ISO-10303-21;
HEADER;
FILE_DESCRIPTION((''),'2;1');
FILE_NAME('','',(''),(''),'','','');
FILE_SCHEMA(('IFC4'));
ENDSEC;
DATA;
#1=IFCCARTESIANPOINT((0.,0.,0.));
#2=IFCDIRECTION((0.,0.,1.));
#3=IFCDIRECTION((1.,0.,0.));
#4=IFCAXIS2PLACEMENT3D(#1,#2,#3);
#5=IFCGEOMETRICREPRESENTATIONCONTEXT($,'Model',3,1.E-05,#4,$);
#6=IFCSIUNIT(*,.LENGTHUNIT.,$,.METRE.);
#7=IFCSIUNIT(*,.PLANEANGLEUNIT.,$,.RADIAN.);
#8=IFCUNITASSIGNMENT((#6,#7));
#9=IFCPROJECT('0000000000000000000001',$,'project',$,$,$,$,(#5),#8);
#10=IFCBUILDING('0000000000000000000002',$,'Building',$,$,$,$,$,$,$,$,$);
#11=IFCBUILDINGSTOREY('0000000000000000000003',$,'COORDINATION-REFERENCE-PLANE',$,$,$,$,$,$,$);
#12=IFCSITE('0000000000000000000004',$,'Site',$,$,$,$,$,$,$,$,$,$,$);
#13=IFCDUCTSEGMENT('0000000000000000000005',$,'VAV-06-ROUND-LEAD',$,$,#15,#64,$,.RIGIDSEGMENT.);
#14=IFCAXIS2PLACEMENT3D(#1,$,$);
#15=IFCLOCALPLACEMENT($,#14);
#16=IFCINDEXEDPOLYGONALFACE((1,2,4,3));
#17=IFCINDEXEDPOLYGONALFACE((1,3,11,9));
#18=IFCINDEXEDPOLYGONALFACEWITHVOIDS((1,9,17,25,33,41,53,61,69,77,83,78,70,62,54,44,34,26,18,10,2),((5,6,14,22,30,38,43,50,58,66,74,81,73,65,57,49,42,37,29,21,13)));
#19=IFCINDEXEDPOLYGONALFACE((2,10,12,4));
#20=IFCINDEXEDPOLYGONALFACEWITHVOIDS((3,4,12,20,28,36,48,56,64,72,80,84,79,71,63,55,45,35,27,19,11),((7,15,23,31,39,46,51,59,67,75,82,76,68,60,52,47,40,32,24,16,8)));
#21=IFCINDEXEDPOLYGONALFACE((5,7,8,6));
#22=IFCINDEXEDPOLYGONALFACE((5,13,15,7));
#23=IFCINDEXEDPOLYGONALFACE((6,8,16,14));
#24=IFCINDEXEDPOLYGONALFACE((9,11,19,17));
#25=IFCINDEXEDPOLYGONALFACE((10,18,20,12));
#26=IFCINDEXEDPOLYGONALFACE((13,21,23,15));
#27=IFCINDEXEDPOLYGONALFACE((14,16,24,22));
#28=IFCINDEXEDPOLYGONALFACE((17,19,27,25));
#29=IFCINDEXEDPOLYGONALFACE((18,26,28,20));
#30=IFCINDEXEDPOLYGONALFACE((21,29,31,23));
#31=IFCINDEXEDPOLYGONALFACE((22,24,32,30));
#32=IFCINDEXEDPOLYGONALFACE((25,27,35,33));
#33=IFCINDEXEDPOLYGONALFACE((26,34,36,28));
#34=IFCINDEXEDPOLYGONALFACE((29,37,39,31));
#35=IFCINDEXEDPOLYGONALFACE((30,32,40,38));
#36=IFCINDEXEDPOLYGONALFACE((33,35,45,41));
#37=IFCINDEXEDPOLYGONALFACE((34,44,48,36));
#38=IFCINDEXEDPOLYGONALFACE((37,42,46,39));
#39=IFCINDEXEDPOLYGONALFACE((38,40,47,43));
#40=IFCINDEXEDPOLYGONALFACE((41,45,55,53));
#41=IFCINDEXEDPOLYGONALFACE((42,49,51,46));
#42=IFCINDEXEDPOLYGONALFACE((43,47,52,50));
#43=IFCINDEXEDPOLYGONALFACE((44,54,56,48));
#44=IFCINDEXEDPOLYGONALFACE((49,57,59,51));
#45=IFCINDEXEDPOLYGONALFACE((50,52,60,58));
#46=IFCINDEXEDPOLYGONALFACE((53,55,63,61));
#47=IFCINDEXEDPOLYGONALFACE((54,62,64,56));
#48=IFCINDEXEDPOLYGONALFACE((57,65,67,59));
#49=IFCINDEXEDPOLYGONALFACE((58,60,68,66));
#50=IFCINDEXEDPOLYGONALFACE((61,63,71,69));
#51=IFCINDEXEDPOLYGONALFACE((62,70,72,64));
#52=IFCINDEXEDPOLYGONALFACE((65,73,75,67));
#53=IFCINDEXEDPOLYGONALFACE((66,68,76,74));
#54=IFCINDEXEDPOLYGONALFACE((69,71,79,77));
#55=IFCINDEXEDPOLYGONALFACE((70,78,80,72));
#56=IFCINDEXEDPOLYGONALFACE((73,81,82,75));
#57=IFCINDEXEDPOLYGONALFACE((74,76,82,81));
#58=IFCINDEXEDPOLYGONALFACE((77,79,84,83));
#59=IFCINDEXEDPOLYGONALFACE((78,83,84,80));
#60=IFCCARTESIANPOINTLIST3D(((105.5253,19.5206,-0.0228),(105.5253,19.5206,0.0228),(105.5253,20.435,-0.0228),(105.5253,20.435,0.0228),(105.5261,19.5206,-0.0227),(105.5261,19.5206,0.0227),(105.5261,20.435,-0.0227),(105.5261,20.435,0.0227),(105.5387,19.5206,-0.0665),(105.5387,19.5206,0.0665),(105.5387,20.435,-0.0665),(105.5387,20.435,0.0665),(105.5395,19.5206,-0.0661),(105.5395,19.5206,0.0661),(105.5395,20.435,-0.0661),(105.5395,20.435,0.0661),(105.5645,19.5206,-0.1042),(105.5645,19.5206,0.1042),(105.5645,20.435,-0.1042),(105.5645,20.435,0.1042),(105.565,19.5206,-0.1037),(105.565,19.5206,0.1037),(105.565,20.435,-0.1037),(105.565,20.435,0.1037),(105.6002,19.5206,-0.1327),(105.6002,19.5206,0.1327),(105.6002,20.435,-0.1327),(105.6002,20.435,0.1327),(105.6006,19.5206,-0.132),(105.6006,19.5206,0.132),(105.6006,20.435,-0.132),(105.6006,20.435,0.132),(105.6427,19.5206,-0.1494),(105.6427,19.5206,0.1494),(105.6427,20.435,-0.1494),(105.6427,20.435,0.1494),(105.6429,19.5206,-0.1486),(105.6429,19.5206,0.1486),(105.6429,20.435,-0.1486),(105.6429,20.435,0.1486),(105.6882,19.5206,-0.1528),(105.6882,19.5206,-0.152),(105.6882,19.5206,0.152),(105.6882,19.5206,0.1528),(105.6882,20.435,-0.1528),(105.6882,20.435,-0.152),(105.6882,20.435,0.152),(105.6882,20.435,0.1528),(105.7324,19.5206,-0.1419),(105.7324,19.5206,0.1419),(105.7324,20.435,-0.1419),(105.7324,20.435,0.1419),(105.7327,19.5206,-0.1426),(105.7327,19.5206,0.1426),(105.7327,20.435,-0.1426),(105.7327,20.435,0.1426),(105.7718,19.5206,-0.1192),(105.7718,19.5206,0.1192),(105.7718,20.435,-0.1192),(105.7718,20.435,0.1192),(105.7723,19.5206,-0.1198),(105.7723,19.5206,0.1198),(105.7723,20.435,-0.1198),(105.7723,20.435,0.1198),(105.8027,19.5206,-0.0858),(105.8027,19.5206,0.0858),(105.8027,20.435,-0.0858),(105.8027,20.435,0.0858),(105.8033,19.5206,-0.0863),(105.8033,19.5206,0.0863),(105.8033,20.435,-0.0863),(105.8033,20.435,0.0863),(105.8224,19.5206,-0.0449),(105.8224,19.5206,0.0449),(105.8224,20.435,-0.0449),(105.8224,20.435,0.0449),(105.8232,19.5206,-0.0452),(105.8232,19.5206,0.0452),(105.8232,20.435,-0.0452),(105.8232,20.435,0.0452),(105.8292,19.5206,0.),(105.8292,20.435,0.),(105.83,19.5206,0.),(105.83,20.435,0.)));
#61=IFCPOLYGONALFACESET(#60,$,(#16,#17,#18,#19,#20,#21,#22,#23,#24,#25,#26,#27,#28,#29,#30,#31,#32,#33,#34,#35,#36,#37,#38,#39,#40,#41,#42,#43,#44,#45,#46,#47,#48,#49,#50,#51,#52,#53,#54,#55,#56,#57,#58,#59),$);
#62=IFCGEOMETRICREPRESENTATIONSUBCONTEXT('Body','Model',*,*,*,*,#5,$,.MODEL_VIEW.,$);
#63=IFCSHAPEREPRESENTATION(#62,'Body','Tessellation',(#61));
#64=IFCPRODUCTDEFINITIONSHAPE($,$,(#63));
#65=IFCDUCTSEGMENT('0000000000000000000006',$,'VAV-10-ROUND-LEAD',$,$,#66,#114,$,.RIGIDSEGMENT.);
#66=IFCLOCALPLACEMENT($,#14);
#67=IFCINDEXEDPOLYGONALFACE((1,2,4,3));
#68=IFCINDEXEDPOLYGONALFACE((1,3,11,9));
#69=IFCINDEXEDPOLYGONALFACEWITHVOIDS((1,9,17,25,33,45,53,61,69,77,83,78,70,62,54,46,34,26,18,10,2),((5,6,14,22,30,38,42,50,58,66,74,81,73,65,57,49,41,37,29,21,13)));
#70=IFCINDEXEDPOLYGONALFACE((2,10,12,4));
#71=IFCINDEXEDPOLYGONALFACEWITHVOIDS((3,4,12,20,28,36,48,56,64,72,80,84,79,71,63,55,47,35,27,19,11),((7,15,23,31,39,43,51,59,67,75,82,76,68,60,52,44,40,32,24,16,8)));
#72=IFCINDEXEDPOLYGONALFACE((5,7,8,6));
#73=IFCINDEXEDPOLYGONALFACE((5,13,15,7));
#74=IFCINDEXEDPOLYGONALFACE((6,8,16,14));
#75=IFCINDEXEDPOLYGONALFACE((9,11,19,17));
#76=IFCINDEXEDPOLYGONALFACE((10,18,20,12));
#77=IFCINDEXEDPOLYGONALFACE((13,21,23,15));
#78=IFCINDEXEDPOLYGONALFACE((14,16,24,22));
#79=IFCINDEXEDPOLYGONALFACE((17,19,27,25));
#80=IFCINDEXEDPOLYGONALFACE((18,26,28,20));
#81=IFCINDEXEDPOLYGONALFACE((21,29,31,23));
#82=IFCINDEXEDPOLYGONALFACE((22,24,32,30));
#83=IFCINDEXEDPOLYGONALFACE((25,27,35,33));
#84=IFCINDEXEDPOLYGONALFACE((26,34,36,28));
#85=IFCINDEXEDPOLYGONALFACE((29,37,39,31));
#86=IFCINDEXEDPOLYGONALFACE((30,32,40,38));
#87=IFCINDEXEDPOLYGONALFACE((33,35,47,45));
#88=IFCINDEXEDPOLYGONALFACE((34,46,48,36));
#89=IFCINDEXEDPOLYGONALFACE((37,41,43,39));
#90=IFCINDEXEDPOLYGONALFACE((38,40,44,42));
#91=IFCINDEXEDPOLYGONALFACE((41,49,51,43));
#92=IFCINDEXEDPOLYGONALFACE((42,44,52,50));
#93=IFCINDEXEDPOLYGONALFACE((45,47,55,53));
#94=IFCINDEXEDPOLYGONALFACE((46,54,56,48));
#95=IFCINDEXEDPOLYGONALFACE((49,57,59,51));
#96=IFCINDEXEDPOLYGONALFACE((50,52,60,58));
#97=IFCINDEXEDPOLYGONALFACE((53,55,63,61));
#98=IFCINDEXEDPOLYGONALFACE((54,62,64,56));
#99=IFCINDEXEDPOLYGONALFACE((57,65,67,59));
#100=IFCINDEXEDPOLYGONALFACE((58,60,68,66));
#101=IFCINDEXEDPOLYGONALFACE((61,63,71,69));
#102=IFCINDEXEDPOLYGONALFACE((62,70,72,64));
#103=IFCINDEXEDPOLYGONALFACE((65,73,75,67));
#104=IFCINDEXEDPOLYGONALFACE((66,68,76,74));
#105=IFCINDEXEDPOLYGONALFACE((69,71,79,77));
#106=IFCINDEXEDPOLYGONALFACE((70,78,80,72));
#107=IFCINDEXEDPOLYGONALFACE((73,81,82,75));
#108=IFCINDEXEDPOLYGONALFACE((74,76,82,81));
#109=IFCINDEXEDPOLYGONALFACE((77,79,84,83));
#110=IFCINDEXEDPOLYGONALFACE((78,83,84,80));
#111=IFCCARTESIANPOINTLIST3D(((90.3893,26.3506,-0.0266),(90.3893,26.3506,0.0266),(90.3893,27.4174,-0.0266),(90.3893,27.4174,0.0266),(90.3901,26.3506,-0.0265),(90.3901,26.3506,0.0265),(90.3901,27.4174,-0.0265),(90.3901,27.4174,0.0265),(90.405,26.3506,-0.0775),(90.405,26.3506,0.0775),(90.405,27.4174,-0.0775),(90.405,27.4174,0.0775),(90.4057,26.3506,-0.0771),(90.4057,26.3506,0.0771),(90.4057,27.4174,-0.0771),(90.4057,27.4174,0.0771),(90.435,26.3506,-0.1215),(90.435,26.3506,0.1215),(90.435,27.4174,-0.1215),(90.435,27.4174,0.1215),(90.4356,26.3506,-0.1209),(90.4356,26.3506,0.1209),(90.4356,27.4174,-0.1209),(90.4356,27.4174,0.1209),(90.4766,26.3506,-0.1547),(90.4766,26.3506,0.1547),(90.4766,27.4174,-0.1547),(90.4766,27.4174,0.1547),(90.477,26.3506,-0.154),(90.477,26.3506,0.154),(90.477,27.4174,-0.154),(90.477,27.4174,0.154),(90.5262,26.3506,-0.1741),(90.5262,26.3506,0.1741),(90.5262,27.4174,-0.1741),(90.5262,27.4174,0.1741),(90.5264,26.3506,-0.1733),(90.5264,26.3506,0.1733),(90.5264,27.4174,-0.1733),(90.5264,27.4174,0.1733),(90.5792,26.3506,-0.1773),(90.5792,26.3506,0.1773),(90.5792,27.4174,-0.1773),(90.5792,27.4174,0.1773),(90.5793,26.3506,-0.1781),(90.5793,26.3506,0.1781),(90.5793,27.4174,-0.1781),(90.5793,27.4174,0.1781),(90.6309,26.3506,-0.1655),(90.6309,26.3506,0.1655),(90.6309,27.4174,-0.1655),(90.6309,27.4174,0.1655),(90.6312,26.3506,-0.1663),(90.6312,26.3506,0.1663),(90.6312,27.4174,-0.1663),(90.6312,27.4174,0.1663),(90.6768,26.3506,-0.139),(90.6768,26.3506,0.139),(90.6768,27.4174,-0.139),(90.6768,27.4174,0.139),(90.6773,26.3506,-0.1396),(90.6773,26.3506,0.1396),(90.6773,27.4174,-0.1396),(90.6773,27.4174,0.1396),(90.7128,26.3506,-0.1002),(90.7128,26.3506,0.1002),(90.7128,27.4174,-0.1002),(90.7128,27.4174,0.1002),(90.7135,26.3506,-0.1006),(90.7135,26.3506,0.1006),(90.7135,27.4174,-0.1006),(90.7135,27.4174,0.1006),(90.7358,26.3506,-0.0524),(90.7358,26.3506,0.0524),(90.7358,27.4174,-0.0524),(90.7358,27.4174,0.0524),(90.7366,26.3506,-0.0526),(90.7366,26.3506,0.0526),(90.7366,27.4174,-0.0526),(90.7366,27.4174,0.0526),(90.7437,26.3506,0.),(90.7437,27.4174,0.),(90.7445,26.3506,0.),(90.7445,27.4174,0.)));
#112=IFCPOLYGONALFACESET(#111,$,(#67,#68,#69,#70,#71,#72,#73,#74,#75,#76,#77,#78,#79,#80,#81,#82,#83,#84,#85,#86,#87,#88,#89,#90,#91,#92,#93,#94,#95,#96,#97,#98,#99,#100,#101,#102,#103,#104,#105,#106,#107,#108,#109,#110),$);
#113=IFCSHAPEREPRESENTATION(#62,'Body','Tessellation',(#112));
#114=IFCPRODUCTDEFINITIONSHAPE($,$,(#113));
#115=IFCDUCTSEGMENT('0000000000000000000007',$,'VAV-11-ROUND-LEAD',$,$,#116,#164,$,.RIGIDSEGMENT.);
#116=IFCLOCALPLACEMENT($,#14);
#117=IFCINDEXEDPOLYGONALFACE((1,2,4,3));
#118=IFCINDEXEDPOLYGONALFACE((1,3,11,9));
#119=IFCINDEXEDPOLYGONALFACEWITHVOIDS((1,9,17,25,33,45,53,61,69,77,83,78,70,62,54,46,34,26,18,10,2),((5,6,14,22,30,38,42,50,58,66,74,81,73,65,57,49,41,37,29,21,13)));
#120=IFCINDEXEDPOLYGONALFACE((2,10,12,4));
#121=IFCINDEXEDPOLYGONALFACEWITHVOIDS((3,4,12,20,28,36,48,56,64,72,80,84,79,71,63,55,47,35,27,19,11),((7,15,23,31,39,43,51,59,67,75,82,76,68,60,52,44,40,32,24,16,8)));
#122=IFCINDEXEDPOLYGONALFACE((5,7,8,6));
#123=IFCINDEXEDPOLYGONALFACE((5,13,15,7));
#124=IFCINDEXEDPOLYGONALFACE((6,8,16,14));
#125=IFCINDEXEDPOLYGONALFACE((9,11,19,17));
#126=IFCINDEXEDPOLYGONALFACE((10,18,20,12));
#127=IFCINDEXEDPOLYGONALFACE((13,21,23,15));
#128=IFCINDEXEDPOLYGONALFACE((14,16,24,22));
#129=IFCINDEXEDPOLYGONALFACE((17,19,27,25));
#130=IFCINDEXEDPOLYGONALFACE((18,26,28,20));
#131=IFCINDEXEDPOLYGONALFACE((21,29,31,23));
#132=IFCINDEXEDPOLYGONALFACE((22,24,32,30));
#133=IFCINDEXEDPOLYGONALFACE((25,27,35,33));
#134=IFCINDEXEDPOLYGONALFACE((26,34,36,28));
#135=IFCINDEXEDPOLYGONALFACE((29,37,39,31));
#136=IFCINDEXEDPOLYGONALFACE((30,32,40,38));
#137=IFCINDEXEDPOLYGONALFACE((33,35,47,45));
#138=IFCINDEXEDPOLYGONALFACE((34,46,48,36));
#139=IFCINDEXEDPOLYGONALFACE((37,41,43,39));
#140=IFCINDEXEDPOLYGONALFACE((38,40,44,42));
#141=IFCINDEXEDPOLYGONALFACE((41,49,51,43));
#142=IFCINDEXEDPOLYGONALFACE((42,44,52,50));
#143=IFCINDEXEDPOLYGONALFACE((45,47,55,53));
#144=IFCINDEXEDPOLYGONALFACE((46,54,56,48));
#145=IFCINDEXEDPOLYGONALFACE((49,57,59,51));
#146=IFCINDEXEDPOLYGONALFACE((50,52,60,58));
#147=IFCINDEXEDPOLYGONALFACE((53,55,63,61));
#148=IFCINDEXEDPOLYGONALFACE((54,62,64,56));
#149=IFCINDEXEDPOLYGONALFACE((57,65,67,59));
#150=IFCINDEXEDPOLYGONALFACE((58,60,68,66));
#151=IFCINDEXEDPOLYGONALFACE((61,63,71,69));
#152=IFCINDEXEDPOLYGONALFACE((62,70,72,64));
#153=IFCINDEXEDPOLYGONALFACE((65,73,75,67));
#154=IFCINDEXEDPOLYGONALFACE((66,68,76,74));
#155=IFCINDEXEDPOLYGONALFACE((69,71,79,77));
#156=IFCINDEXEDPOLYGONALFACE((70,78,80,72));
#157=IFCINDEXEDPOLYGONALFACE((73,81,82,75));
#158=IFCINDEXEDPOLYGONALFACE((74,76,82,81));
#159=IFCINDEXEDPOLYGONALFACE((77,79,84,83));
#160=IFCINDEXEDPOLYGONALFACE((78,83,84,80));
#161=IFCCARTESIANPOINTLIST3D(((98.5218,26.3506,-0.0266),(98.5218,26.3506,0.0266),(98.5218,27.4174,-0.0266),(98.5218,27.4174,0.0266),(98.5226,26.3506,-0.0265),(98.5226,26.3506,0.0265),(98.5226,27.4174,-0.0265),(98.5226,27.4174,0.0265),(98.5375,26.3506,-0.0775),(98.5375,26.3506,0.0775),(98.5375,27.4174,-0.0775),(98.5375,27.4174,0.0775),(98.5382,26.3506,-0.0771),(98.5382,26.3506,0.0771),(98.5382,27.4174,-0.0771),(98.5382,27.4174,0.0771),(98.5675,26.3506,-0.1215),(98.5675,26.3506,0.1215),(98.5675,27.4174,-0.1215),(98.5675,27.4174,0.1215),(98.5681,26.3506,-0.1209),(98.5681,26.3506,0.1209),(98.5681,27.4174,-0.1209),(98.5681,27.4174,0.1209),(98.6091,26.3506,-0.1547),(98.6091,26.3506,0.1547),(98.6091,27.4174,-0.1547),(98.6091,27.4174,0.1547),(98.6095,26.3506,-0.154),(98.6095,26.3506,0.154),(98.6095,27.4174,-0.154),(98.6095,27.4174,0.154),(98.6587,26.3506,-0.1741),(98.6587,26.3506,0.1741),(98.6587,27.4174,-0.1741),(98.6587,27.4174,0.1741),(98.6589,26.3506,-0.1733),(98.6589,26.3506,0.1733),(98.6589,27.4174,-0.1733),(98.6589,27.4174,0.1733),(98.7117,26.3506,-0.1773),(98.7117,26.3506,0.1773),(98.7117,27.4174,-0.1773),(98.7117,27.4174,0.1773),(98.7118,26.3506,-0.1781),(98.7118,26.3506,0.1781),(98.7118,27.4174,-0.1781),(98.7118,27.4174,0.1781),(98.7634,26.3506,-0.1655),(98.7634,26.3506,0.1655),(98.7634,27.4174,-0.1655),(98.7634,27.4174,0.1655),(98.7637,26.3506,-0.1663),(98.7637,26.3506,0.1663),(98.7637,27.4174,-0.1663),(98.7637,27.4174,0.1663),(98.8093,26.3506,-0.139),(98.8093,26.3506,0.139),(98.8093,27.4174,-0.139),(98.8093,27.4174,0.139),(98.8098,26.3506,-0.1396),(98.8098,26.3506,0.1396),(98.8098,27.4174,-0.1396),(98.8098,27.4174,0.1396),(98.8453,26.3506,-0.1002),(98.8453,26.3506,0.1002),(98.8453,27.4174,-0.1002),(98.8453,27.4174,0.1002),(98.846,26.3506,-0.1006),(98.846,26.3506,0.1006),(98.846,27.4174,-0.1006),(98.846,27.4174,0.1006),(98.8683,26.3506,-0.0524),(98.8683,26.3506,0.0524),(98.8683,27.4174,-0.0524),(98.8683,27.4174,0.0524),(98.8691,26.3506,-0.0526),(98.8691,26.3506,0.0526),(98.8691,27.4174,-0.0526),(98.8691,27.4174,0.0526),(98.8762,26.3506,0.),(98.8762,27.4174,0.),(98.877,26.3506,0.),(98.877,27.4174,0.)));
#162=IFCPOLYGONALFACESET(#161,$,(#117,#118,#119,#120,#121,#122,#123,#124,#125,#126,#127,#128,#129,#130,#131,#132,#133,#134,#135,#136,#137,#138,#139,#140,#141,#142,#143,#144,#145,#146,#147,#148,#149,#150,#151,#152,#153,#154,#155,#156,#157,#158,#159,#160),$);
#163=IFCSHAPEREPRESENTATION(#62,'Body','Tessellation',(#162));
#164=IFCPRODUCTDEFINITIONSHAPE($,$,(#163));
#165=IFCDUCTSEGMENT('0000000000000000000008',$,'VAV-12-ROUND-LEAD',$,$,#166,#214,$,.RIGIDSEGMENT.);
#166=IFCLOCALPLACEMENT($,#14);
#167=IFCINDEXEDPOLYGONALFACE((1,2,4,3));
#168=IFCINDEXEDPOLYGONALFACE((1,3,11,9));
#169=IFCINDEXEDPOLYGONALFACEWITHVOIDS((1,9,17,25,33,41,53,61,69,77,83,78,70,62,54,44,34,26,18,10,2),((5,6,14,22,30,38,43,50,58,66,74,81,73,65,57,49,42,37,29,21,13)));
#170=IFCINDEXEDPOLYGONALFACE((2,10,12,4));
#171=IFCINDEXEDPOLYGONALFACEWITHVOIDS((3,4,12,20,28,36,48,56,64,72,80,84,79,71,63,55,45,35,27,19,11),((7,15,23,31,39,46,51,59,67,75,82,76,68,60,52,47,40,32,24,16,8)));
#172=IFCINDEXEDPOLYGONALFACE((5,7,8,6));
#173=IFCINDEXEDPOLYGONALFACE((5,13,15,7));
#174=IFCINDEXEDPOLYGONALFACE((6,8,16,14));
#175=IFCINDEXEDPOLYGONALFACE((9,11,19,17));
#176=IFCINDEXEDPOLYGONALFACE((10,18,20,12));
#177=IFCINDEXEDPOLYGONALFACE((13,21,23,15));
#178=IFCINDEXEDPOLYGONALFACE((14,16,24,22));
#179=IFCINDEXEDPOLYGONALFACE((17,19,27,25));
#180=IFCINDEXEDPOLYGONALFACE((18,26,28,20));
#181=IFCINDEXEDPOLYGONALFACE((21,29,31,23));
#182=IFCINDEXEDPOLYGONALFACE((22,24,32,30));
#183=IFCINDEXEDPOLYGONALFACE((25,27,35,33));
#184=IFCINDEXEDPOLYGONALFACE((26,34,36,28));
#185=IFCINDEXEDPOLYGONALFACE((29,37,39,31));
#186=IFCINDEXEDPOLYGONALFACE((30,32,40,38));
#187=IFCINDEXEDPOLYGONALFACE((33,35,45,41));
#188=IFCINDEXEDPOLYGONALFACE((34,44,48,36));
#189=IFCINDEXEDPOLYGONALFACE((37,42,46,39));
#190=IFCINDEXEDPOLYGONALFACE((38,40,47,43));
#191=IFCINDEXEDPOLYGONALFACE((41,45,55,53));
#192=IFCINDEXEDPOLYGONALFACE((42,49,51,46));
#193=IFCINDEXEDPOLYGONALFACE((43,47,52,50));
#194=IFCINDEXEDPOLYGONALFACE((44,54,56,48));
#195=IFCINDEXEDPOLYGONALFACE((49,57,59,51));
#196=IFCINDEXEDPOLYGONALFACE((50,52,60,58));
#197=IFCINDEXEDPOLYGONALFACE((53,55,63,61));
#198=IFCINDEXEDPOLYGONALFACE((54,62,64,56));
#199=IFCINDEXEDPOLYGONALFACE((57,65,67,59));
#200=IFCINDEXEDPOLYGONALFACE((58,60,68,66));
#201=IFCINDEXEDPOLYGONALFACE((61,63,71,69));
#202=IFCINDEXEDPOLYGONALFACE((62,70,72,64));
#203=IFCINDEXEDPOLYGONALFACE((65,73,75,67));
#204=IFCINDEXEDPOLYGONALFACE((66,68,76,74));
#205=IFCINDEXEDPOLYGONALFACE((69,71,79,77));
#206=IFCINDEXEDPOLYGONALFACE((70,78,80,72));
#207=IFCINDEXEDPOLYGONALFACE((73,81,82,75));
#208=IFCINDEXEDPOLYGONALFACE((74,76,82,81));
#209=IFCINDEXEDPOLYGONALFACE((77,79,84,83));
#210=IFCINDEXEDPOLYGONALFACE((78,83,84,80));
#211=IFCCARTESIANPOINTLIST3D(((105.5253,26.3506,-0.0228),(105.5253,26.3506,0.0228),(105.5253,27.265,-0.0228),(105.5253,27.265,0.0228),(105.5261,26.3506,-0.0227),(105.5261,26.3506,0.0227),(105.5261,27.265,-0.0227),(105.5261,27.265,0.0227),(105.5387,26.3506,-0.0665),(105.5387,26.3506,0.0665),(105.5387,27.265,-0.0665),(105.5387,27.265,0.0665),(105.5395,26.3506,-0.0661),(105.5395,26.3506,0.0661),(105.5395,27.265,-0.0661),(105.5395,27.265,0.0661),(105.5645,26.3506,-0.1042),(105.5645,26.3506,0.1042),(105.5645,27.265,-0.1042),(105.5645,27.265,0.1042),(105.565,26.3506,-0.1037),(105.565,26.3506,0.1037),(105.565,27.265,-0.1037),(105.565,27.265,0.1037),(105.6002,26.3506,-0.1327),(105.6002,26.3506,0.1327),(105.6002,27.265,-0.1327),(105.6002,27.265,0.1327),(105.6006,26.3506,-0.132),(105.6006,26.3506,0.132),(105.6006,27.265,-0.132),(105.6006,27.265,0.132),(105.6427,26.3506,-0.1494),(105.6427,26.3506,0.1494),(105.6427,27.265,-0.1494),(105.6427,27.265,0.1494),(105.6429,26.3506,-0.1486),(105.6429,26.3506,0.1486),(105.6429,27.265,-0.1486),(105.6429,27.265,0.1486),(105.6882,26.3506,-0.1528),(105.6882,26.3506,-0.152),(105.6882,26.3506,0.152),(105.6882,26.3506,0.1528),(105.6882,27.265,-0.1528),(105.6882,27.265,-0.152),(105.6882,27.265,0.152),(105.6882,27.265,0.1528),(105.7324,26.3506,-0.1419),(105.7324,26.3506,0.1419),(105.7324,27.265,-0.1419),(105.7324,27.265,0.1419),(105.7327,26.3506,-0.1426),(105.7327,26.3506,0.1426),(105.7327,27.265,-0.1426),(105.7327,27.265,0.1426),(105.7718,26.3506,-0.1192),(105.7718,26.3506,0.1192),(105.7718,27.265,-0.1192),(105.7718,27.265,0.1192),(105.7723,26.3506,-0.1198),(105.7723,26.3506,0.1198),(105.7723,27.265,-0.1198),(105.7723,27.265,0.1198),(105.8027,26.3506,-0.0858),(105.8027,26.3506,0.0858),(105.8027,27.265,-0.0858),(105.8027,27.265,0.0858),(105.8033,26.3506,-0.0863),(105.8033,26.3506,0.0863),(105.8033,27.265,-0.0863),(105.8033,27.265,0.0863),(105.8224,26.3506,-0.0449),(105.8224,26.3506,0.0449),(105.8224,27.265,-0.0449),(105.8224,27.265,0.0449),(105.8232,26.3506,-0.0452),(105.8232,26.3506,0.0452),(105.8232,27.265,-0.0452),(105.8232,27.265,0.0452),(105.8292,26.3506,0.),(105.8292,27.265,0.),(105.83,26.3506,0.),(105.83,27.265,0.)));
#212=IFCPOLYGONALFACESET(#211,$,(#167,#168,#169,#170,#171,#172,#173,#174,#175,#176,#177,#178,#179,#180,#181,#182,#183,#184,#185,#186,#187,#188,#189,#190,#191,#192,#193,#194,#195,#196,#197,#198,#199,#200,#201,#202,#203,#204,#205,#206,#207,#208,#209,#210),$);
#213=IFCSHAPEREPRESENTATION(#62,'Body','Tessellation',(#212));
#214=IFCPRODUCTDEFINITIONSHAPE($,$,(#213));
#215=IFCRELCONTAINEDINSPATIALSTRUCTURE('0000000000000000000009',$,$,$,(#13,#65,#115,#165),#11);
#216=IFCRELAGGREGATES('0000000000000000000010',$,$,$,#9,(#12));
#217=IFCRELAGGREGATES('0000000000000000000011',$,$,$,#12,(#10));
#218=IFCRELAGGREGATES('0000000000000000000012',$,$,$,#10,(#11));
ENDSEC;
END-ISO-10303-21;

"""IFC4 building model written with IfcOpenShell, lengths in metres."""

from ifc_helpers import new_model, si_unit, frame, origin, origin_with_axes, place, context, subcontext, project, spatial, hollow_circle, extrude, element, save


model = new_model("IFC4")

# Units and contexts
model_context = context("Model", 3, precision=1e-05, world=origin_with_axes())
body_context_1 = subcontext(model_context, "Body", "Model", "MODEL_VIEW")
ifc_project = project(units=[si_unit("LENGTHUNIT", "METRE"), si_unit("PLANEANGLEUNIT", "RADIAN")], contexts=[model_context])

# Site, building, storey
site = spatial("IfcSite", under=ifc_project, Name="Site")
building = spatial("IfcBuilding", under=site, Name="Building")
storey = spatial("IfcBuildingStorey", under=building, Name="COORDINATION-REFERENCE-PLANE")

# Duct segments
duct_segment_1_placement = place(None, frame((105.6768, 20.435, 0.0), z_axis=(0.0, -1.0, 0.0), x_axis=(1.0, 0.0, 0.0)))
element("IfcDuctSegment", 1, at=duct_segment_1_placement, inside=storey, Name="VAV-06-ROUND-LEAD", PredefinedType="RIGIDSEGMENT", context=body_context_1, shape_type="SweptSolid", body=[
    extrude(hollow_circle(Radius=0.1532, WallThickness=0.0008), origin(), (0.0, 0.0, 1.0), 0.9144),
])
for number, where, z_axis, x_axis, name in (
    (2, (90.5659, 27.4174, 0.0), (0.0, -1.0, 0.0), (1.0, 0.0, 0.0), "VAV-10-ROUND-LEAD"),
    (3, (98.6984, 27.4174, 0.0), (0.0, -1.0, 0.0), (1.0, 0.0, 0.0), "VAV-11-ROUND-LEAD"),
):
    element("IfcDuctSegment", number, at=place(None, frame(where, z_axis=z_axis, x_axis=x_axis)), inside=storey, Name=name, PredefinedType="RIGIDSEGMENT", context=body_context_1, shape_type="SweptSolid", body=[
        extrude(hollow_circle(Radius=0.1786, WallThickness=0.0008), origin(), (0.0, 0.0, 1.0), 1.0668),
    ])
duct_segment_2_placement = place(None, frame((105.6768, 27.265, 0.0), z_axis=(0.0, -1.0, 0.0), x_axis=(1.0, 0.0, 0.0)))
element("IfcDuctSegment", 4, at=duct_segment_2_placement, inside=storey, Name="VAV-12-ROUND-LEAD", PredefinedType="RIGIDSEGMENT", context=body_context_1, shape_type="SweptSolid", body=[
    extrude(hollow_circle(Radius=0.1532, WallThickness=0.0008), origin(), (0.0, 0.0, 1.0), 0.9144),
])

save(model, "model.ifc")
